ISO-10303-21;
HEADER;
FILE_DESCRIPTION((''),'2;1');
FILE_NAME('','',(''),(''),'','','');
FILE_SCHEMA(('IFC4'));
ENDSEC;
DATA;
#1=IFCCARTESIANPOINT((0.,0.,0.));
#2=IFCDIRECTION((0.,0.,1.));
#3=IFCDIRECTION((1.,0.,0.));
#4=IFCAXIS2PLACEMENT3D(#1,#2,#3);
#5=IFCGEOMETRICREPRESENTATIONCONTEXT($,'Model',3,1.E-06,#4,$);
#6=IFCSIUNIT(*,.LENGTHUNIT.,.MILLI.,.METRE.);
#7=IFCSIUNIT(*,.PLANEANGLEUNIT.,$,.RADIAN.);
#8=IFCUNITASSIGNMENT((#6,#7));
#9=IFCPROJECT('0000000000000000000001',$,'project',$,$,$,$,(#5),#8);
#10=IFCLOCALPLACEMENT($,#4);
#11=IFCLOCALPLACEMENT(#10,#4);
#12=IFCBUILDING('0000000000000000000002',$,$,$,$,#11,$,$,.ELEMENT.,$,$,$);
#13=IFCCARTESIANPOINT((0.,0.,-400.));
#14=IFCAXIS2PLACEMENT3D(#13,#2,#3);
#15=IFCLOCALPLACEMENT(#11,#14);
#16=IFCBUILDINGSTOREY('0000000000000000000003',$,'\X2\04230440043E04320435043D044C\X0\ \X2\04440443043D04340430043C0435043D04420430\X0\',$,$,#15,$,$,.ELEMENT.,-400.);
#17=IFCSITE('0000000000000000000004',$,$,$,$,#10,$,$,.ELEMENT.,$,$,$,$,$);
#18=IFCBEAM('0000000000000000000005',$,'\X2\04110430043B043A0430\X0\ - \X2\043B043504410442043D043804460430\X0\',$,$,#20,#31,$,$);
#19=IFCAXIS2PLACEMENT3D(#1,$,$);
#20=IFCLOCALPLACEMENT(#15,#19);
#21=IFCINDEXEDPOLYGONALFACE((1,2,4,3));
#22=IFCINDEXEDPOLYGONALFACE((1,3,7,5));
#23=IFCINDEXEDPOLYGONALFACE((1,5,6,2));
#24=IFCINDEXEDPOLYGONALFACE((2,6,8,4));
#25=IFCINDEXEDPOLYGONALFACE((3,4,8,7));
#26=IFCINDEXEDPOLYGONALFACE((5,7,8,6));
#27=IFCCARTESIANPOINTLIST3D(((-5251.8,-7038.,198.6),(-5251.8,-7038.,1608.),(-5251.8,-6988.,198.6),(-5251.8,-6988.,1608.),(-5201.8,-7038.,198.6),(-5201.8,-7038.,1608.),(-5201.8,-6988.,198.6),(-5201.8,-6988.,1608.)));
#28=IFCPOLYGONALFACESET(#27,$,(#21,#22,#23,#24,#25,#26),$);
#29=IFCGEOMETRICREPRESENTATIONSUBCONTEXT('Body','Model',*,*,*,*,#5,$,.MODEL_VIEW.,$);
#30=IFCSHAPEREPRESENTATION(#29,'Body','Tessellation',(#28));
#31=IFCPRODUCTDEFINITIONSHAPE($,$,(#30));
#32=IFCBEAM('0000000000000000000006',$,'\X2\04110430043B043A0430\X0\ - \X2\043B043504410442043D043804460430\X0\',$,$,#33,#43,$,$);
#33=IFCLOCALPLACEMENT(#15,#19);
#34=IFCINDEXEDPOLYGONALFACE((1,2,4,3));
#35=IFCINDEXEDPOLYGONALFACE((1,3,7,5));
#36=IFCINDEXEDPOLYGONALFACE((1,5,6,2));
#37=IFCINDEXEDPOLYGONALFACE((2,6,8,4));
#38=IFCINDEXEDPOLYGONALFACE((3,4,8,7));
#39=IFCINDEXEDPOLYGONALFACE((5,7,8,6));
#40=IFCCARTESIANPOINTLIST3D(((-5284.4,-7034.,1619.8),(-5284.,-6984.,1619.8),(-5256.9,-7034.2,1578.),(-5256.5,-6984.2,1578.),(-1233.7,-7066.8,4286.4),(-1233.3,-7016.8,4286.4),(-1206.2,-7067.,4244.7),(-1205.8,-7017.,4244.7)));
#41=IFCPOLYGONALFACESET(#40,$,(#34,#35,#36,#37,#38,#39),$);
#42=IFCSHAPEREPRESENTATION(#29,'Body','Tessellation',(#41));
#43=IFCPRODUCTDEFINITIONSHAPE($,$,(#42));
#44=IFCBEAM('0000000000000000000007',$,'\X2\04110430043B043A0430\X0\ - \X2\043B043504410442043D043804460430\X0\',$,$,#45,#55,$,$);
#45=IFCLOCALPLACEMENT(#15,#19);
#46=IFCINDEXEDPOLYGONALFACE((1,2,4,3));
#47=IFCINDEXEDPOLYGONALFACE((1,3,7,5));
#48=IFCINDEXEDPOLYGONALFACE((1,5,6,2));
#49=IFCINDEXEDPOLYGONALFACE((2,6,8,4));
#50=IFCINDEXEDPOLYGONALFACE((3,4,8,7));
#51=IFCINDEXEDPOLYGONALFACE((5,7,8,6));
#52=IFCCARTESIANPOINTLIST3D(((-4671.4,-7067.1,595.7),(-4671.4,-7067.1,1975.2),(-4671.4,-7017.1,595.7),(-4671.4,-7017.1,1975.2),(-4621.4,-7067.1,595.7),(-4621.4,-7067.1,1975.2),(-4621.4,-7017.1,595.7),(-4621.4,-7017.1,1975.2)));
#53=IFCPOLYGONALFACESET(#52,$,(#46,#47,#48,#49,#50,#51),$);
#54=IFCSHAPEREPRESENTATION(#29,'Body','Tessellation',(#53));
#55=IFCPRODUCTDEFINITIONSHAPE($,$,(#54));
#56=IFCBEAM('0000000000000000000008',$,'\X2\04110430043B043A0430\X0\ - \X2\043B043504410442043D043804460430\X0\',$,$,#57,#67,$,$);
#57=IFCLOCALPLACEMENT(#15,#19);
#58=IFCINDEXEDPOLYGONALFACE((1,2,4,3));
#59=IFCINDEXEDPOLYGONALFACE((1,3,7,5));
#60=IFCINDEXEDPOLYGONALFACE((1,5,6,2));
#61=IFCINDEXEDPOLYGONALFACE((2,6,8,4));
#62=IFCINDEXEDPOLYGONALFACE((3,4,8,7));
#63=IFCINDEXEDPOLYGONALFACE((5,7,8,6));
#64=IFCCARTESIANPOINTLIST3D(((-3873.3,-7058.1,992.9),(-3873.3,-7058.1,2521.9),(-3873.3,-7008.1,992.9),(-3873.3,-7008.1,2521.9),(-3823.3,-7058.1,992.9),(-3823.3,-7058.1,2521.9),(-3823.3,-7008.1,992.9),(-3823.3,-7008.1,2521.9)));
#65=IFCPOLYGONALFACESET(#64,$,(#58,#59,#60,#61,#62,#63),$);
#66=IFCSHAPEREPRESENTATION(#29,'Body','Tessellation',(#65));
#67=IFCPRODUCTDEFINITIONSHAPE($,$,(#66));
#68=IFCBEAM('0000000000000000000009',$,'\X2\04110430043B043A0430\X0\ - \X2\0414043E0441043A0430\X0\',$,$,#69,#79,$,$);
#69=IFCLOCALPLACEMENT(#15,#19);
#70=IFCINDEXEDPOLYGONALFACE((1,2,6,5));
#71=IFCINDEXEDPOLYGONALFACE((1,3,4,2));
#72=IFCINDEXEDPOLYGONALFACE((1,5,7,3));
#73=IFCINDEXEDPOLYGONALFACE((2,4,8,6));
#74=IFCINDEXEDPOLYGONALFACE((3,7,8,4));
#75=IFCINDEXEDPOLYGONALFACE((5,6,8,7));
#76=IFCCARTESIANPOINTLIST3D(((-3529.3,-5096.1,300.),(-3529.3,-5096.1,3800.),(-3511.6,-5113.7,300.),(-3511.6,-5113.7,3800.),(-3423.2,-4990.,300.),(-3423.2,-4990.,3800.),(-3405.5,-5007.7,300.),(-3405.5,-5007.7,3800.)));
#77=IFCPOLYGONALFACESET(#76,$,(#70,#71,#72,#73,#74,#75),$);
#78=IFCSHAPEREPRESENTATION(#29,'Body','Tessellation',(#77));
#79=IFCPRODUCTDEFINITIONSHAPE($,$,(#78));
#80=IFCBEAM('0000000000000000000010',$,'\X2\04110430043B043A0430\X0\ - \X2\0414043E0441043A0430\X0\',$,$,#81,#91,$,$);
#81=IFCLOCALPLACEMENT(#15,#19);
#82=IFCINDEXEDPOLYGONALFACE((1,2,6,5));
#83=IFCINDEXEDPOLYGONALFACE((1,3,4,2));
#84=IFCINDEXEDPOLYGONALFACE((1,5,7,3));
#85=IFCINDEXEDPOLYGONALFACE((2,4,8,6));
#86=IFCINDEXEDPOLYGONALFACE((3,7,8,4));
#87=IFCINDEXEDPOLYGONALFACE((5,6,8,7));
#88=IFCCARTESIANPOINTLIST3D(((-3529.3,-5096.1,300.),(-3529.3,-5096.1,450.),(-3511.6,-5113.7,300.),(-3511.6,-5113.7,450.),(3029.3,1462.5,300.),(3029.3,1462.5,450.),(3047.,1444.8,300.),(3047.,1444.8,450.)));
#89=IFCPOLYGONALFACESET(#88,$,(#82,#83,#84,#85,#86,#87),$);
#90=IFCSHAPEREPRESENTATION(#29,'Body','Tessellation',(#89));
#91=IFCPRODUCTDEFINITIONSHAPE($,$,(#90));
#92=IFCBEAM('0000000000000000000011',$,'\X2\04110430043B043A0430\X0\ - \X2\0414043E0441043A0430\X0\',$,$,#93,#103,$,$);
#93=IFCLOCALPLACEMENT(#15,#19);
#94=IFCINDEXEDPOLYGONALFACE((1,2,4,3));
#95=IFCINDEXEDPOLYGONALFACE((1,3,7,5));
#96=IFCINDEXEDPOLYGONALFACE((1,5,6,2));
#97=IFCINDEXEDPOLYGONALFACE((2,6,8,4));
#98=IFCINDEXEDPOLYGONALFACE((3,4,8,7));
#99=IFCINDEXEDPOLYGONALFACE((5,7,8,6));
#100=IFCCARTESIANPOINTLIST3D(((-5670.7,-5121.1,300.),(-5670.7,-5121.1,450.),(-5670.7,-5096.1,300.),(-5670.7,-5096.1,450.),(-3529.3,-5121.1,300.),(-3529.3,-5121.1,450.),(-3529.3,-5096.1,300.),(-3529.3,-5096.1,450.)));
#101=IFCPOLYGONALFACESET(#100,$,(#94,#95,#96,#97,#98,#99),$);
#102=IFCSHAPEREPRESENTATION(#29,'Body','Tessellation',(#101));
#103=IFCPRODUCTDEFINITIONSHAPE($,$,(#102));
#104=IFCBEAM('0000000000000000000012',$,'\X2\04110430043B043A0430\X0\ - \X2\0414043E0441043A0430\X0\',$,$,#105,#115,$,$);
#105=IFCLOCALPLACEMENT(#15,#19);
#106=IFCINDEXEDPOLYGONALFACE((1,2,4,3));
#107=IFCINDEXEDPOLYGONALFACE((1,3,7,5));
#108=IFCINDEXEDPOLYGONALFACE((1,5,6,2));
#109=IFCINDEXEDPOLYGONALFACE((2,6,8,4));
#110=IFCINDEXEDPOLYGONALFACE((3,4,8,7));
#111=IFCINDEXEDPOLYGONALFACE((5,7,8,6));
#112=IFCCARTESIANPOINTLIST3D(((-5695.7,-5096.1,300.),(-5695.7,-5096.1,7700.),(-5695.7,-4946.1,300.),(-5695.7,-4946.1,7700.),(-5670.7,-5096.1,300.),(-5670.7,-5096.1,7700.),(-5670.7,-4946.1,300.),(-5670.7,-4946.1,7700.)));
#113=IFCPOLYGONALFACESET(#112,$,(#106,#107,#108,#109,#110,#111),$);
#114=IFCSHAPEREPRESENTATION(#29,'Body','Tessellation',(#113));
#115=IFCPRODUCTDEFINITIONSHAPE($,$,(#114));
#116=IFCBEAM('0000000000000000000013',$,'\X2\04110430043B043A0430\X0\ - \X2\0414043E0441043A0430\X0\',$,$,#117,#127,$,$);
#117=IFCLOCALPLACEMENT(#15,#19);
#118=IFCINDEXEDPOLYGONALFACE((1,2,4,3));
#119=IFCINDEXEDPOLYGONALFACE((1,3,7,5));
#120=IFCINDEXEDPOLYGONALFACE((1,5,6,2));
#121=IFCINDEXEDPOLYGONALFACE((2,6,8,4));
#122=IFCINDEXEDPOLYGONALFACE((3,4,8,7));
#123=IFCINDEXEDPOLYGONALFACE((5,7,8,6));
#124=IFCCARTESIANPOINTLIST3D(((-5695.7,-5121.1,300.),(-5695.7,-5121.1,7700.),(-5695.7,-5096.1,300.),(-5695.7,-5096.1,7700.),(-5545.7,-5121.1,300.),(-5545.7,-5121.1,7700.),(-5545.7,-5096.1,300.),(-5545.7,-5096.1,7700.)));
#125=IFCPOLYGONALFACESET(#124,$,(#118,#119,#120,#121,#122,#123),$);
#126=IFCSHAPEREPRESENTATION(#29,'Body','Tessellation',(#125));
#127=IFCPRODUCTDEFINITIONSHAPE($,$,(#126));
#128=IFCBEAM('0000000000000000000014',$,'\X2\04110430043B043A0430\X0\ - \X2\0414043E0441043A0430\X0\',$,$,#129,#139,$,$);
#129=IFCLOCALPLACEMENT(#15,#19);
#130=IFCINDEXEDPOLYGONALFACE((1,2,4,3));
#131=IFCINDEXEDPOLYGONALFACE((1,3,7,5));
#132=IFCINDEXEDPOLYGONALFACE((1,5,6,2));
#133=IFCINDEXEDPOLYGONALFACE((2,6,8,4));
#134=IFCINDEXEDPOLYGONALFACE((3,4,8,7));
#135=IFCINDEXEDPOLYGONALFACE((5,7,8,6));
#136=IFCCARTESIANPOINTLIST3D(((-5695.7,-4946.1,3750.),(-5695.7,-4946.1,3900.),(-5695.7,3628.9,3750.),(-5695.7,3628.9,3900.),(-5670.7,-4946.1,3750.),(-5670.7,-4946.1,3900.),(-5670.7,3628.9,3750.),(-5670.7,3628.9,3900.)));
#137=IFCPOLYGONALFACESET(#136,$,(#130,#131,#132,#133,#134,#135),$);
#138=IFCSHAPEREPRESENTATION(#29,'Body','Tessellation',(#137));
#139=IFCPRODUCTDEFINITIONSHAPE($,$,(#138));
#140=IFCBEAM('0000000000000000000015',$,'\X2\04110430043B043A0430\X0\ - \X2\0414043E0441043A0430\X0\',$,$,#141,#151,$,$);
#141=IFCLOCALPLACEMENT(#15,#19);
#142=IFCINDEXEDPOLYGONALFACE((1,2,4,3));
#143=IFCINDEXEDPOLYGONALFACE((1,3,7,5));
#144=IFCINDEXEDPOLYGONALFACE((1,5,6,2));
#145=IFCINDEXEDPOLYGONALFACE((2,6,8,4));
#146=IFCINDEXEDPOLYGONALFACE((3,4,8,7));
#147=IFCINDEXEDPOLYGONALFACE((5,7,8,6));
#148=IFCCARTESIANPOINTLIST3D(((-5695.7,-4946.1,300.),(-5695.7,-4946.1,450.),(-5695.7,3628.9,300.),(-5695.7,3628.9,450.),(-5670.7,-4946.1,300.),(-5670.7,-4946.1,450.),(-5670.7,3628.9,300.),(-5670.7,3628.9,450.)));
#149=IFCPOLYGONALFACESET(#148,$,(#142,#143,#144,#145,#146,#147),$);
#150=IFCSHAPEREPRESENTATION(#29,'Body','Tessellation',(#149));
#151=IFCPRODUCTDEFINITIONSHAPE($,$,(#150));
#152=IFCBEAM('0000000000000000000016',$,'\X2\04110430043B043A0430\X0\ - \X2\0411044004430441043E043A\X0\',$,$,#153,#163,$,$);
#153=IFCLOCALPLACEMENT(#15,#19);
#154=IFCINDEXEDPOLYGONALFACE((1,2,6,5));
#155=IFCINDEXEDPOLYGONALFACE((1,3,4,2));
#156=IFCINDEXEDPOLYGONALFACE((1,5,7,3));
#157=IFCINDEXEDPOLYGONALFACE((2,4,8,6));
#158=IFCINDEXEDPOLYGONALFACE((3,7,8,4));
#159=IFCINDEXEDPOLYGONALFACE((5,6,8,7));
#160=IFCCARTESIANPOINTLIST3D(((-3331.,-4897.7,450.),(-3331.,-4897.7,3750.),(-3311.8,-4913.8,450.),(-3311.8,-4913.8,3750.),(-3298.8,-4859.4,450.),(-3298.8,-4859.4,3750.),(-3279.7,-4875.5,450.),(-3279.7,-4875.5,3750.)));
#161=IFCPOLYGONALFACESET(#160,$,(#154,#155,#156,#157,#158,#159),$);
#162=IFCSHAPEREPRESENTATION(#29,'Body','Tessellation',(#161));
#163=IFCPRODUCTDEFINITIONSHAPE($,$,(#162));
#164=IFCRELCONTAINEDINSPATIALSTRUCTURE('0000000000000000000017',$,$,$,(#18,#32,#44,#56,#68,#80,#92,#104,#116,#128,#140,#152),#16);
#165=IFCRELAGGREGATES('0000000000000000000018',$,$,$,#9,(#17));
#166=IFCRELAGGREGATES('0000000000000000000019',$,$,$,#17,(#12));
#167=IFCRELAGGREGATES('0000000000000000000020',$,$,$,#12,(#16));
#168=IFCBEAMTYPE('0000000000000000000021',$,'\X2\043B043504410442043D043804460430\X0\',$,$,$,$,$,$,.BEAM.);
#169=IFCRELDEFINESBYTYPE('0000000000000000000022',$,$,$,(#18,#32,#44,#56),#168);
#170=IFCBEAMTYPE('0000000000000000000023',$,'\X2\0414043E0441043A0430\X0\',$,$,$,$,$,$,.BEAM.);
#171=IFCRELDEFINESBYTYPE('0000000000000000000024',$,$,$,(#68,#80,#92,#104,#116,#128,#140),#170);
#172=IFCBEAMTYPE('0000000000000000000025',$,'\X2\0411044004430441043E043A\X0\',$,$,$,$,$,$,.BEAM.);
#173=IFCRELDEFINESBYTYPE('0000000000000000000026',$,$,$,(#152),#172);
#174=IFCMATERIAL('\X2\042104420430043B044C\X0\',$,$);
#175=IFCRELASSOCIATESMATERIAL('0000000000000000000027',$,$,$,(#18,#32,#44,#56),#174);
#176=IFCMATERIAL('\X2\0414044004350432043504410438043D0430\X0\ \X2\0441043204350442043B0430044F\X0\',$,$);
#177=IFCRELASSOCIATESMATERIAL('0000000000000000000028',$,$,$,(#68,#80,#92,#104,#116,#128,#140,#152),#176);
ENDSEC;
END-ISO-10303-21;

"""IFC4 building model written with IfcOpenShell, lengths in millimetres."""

from ifc_helpers import new_model, si_unit, frame, origin_with_axes, place, context, subcontext, project, spatial, line, indexed_curve, outline, extrude, source, transform, mapped, material, type_object, element, save


model = new_model("IFC4")

# Units and contexts
model_context = context("Model", 3, precision=1e-06, world=origin_with_axes())
body_context = subcontext(model_context, "Body", "Model", "MODEL_VIEW")
ifc_project = project(units=[si_unit("LENGTHUNIT", "METRE", prefix="MILLI"), si_unit("PLANEANGLEUNIT", "RADIAN")], contexts=[model_context])

# Site, building, storey
site_placement = place(None, origin_with_axes())
site = spatial("IfcSite", under=ifc_project, at=site_placement, CompositionType="ELEMENT")
building_placement = place(site_placement, origin_with_axes())
building = spatial("IfcBuilding", under=site, at=building_placement, CompositionType="ELEMENT")
storey_placement = place(building_placement, frame((0.0, 0.0, -400.0), z_axis=(0.0, 0.0, 1.0), x_axis=(1.0, 0.0, 0.0)))
storey = spatial("IfcBuildingStorey", under=building, at=storey_placement, Name="Уровень фундамента", CompositionType="ELEMENT", Elevation=-400.0)

# Beams
ifc_material_1 = material(Name="Сталь")
beam_type_1 = type_object("IfcBeamType", Name="лестница", PredefinedType="BEAM")
shared_shape_1 = source(origin_with_axes(), body_context, "Body", "SweptSolid", [
    extrude(outline(indexed_curve([(-25.0, 0.0), (25.0, 0.0), (25.0, 50.0), (-25.0, 50.0)], segments=[line(1, 2), line(2, 3), line(3, 4), line(4, 1)])), origin_with_axes(), (0.0, 0.0, -1.0), 1409.4),
])
beam_1_placement = place(storey_placement, frame((-5226.8, -7038.0, 198.6), z_axis=(0.0, 0.0, -1.0), x_axis=(-1.0, 0.0, 0.0)))
element("IfcBeam", 1, at=beam_1_placement, inside=storey, type_object=beam_type_1, material=ifc_material_1, Name="Балка - лестница", context=body_context, shape_type="MappedRepresentation", body=[
    mapped(shared_shape_1, transform((0.0, 0.0, 0.0), x_axis=(1.0, 0.0, 0.0), y_axis=(0.0, 1.0, 0.0), z_axis=(0.0, 0.0, 1.0), scale=1.0)),
])
shared_shape_2 = source(origin_with_axes(), body_context, "Body", "SweptSolid", [
    extrude(outline(indexed_curve([(-25.0, 0.0), (25.0, 0.0), (25.0, 50.0), (-25.0, 50.0)], segments=[line(1, 2), line(2, 3), line(3, 4), line(4, 1)])), origin_with_axes(), (0.0, 0.0, -1.0), 4849.8),
])
beam_2_placement = place(storey_placement, frame((-5256.7, -7009.2, 1578.0), z_axis=(-0.835236, 0.006766, -0.54985), x_axis=(-0.0081, -0.999967, 0.0)))
element("IfcBeam", 2, at=beam_2_placement, inside=storey, type_object=beam_type_1, material=ifc_material_1, Name="Балка - лестница", context=body_context, shape_type="MappedRepresentation", body=[
    mapped(shared_shape_2, transform((0.0, 0.0, 0.0), x_axis=(1.0, 0.0, 0.0), y_axis=(0.0, 1.0, 0.0), z_axis=(0.0, 0.0, 1.0), scale=1.0)),
])
shared_shape_3 = source(origin_with_axes(), body_context, "Body", "SweptSolid", [
    extrude(outline(indexed_curve([(-25.0, 0.0), (25.0, 0.0), (25.0, 50.0), (-25.0, 50.0)], segments=[line(1, 2), line(2, 3), line(3, 4), line(4, 1)])), origin_with_axes(), (0.0, 0.0, -1.0), 1379.5),
])
beam_3_placement = place(storey_placement, frame((-4646.4, -7067.1, 595.7), z_axis=(0.0, 0.0, -1.0), x_axis=(-1.0, 0.0, 0.0)))
element("IfcBeam", 3, at=beam_3_placement, inside=storey, type_object=beam_type_1, material=ifc_material_1, Name="Балка - лестница", context=body_context, shape_type="MappedRepresentation", body=[
    mapped(shared_shape_3, transform((0.0, 0.0, 0.0), x_axis=(1.0, 0.0, 0.0), y_axis=(0.0, 1.0, 0.0), z_axis=(0.0, 0.0, 1.0), scale=1.0)),
])
shared_shape_4 = source(origin_with_axes(), body_context, "Body", "SweptSolid", [
    extrude(outline(indexed_curve([(-25.0, 0.0), (25.0, 0.0), (25.0, 50.0), (-25.0, 50.0)], segments=[line(1, 2), line(2, 3), line(3, 4), line(4, 1)])), origin_with_axes(), (0.0, 0.0, -1.0), 1529.0),
])
beam_4_placement = place(storey_placement, frame((-3848.3, -7058.1, 992.9), z_axis=(0.0, 0.0, -1.0), x_axis=(-1.0, 0.0, 0.0)))
element("IfcBeam", 4, at=beam_4_placement, inside=storey, type_object=beam_type_1, material=ifc_material_1, Name="Балка - лестница", context=body_context, shape_type="MappedRepresentation", body=[
    mapped(shared_shape_4, transform((0.0, 0.0, 0.0), x_axis=(1.0, 0.0, 0.0), y_axis=(0.0, 1.0, 0.0), z_axis=(0.0, 0.0, 1.0), scale=1.0)),
])
ifc_material_2 = material(Name="Древесина светлая")
beam_type_2 = type_object("IfcBeamType", Name="Доска", PredefinedType="BEAM")
shared_shape_5 = source(origin_with_axes(), body_context, "Body", "SweptSolid", [
    extrude(outline(indexed_curve([(-75.0, 0.0), (75.0, 0.0), (75.0, 25.0), (-75.0, 25.0)], segments=[line(1, 2), line(2, 3), line(3, 4), line(4, 1)])), origin_with_axes(), (0.0, 0.0, -1.0), 3500.0),
])
beam_5_placement = place(storey_placement, frame((-3476.2, -5043.0, 300.0), z_axis=(0.0, 0.0, -1.0), x_axis=(0.707107, 0.707107, 0.0)))
element("IfcBeam", 5, at=beam_5_placement, inside=storey, type_object=beam_type_2, material=ifc_material_2, Name="Балка - Доска", context=body_context, shape_type="MappedRepresentation", body=[
    mapped(shared_shape_5, transform((0.0, 0.0, 0.0), x_axis=(1.0, 0.0, 0.0), y_axis=(0.0, 1.0, 0.0), z_axis=(0.0, 0.0, 1.0), scale=1.0)),
])
shared_shape_6 = source(origin_with_axes(), body_context, "Body", "SweptSolid", [
    extrude(outline(indexed_curve([(-75.0, 0.0), (75.0, 0.0), (75.0, 25.0), (-75.0, 25.0)], segments=[line(1, 2), line(2, 3), line(3, 4), line(4, 1)])), origin_with_axes(), (0.0, 0.0, -1.0), 9275.2),
])
beam_6_placement = place(storey_placement, frame((-3511.6, -5113.7, 375.0), z_axis=(-0.707107, -0.707107, 0.0), x_axis=(0.0, 0.0, 1.0)))
element("IfcBeam", 6, at=beam_6_placement, inside=storey, type_object=beam_type_2, material=ifc_material_2, Name="Балка - Доска", context=body_context, shape_type="MappedRepresentation", body=[
    mapped(shared_shape_6, transform((0.0, 0.0, 0.0), x_axis=(1.0, 0.0, 0.0), y_axis=(0.0, 1.0, 0.0), z_axis=(0.0, 0.0, 1.0), scale=1.0)),
])
shared_shape_7 = source(origin_with_axes(), body_context, "Body", "SweptSolid", [
    extrude(outline(indexed_curve([(-75.0, 0.0), (75.0, 0.0), (75.0, 25.0), (-75.0, 25.0)], segments=[line(1, 2), line(2, 3), line(3, 4), line(4, 1)])), origin_with_axes(), (0.0, 0.0, -1.0), 2141.4),
])
beam_7_placement = place(storey_placement, frame((-3529.3, -5096.1, 375.0), z_axis=(1.0, 0.0, 0.0), x_axis=(0.0, 0.0, 1.0)))
element("IfcBeam", 7, at=beam_7_placement, inside=storey, type_object=beam_type_2, material=ifc_material_2, Name="Балка - Доска", context=body_context, shape_type="MappedRepresentation", body=[
    mapped(shared_shape_7, transform((0.0, 0.0, 0.0), x_axis=(1.0, 0.0, 0.0), y_axis=(0.0, 1.0, 0.0), z_axis=(0.0, 0.0, 1.0), scale=1.0)),
])
shared_shape_8 = source(origin_with_axes(), body_context, "Body", "SweptSolid", [
    extrude(outline(indexed_curve([(0.0, 0.0), (150.0, 0.0), (150.0, 25.0), (0.0, 25.0)], segments=[line(1, 2), line(2, 3), line(3, 4), line(4, 1)])), origin_with_axes(), (0.0, 0.0, -1.0), 7400.0),
])
beam_8_placement = place(storey_placement, frame((-5670.7, -5096.1, 7700.0), z_axis=(0.0, 0.0, 1.0), x_axis=(0.0, 1.0, 0.0)))
element("IfcBeam", 8, at=beam_8_placement, inside=storey, type_object=beam_type_2, material=ifc_material_2, Name="Балка - Доска", context=body_context, shape_type="MappedRepresentation", body=[
    mapped(shared_shape_8, transform((0.0, 0.0, 0.0), x_axis=(1.0, 0.0, 0.0), y_axis=(0.0, 1.0, 0.0), z_axis=(0.0, 0.0, 1.0), scale=1.0)),
])
shared_shape_9 = source(origin_with_axes(), body_context, "Body", "SweptSolid", [
    extrude(outline(indexed_curve([(0.0, -25.0), (150.0, -25.0), (150.0, 0.0), (0.0, 0.0)], segments=[line(1, 2), line(2, 3), line(3, 4), line(4, 1)])), origin_with_axes(), (0.0, 0.0, -1.0), 7400.0),
])
beam_9_placement = place(storey_placement, frame((-5695.7, -5096.1, 7700.0), z_axis=(0.0, 0.0, 1.0), x_axis=(1.0, 0.0, 0.0)))
element("IfcBeam", 9, at=beam_9_placement, inside=storey, type_object=beam_type_2, material=ifc_material_2, Name="Балка - Доска", context=body_context, shape_type="MappedRepresentation", body=[
    mapped(shared_shape_9, transform((0.0, 0.0, 0.0), x_axis=(1.0, 0.0, 0.0), y_axis=(0.0, 1.0, 0.0), z_axis=(0.0, 0.0, 1.0), scale=1.0)),
])
shared_shape_10 = source(origin_with_axes(), body_context, "Body", "SweptSolid", [
    extrude(outline(indexed_curve([(-75.0, 0.0), (75.0, 0.0), (75.0, 25.0), (-75.0, 25.0)], segments=[line(1, 2), line(2, 3), line(3, 4), line(4, 1)])), origin_with_axes(), (0.0, 0.0, -1.0), 8575.0),
])
for number, where, z_axis, x_axis, name in (
    (10, (-5670.7, -4946.1, 3825.0), (0.0, -1.0, 0.0), (0.0, 0.0, 1.0), "Балка - Доска"),
    (11, (-5670.7, -4946.1, 375.0), (0.0, -1.0, 0.0), (0.0, 0.0, 1.0), "Балка - Доска"),
):
    element("IfcBeam", number, at=place(storey_placement, frame(where, z_axis=z_axis, x_axis=x_axis)), inside=storey, type_object=beam_type_2, material=ifc_material_2, Name=name, context=body_context, shape_type="MappedRepresentation", body=[
        mapped(shared_shape_10, transform((0.0, 0.0, 0.0), x_axis=(1.0, 0.0, 0.0), y_axis=(0.0, 1.0, 0.0), z_axis=(0.0, 0.0, 1.0), scale=1.0)),
    ])
beam_type_3 = type_object("IfcBeamType", Name="Брусок", PredefinedType="BEAM")
shared_shape_11 = source(origin_with_axes(), body_context, "Body", "SweptSolid", [
    extrude(outline(indexed_curve([(0.0, 0.0), (50.0, 0.0), (50.0, 25.0), (0.0, 25.0)], segments=[line(1, 2), line(2, 3), line(3, 4), line(4, 1)])), origin_with_axes(), (0.0, 0.0, -1.0), 3300.0),
])
beam_10_placement = place(storey_placement, frame((-3331.0, -4897.7, 450.0), z_axis=(0.0, 0.0, -1.0), x_axis=(0.642788, 0.766044, 0.0)))
element("IfcBeam", 12, at=beam_10_placement, inside=storey, type_object=beam_type_3, material=ifc_material_2, Name="Балка - Брусок", context=body_context, shape_type="MappedRepresentation", body=[
    mapped(shared_shape_11, transform((0.0, 0.0, 0.0), x_axis=(1.0, 0.0, 0.0), y_axis=(0.0, 1.0, 0.0), z_axis=(0.0, 0.0, 1.0), scale=1.0)),
])

save(model, "model.ifc")
